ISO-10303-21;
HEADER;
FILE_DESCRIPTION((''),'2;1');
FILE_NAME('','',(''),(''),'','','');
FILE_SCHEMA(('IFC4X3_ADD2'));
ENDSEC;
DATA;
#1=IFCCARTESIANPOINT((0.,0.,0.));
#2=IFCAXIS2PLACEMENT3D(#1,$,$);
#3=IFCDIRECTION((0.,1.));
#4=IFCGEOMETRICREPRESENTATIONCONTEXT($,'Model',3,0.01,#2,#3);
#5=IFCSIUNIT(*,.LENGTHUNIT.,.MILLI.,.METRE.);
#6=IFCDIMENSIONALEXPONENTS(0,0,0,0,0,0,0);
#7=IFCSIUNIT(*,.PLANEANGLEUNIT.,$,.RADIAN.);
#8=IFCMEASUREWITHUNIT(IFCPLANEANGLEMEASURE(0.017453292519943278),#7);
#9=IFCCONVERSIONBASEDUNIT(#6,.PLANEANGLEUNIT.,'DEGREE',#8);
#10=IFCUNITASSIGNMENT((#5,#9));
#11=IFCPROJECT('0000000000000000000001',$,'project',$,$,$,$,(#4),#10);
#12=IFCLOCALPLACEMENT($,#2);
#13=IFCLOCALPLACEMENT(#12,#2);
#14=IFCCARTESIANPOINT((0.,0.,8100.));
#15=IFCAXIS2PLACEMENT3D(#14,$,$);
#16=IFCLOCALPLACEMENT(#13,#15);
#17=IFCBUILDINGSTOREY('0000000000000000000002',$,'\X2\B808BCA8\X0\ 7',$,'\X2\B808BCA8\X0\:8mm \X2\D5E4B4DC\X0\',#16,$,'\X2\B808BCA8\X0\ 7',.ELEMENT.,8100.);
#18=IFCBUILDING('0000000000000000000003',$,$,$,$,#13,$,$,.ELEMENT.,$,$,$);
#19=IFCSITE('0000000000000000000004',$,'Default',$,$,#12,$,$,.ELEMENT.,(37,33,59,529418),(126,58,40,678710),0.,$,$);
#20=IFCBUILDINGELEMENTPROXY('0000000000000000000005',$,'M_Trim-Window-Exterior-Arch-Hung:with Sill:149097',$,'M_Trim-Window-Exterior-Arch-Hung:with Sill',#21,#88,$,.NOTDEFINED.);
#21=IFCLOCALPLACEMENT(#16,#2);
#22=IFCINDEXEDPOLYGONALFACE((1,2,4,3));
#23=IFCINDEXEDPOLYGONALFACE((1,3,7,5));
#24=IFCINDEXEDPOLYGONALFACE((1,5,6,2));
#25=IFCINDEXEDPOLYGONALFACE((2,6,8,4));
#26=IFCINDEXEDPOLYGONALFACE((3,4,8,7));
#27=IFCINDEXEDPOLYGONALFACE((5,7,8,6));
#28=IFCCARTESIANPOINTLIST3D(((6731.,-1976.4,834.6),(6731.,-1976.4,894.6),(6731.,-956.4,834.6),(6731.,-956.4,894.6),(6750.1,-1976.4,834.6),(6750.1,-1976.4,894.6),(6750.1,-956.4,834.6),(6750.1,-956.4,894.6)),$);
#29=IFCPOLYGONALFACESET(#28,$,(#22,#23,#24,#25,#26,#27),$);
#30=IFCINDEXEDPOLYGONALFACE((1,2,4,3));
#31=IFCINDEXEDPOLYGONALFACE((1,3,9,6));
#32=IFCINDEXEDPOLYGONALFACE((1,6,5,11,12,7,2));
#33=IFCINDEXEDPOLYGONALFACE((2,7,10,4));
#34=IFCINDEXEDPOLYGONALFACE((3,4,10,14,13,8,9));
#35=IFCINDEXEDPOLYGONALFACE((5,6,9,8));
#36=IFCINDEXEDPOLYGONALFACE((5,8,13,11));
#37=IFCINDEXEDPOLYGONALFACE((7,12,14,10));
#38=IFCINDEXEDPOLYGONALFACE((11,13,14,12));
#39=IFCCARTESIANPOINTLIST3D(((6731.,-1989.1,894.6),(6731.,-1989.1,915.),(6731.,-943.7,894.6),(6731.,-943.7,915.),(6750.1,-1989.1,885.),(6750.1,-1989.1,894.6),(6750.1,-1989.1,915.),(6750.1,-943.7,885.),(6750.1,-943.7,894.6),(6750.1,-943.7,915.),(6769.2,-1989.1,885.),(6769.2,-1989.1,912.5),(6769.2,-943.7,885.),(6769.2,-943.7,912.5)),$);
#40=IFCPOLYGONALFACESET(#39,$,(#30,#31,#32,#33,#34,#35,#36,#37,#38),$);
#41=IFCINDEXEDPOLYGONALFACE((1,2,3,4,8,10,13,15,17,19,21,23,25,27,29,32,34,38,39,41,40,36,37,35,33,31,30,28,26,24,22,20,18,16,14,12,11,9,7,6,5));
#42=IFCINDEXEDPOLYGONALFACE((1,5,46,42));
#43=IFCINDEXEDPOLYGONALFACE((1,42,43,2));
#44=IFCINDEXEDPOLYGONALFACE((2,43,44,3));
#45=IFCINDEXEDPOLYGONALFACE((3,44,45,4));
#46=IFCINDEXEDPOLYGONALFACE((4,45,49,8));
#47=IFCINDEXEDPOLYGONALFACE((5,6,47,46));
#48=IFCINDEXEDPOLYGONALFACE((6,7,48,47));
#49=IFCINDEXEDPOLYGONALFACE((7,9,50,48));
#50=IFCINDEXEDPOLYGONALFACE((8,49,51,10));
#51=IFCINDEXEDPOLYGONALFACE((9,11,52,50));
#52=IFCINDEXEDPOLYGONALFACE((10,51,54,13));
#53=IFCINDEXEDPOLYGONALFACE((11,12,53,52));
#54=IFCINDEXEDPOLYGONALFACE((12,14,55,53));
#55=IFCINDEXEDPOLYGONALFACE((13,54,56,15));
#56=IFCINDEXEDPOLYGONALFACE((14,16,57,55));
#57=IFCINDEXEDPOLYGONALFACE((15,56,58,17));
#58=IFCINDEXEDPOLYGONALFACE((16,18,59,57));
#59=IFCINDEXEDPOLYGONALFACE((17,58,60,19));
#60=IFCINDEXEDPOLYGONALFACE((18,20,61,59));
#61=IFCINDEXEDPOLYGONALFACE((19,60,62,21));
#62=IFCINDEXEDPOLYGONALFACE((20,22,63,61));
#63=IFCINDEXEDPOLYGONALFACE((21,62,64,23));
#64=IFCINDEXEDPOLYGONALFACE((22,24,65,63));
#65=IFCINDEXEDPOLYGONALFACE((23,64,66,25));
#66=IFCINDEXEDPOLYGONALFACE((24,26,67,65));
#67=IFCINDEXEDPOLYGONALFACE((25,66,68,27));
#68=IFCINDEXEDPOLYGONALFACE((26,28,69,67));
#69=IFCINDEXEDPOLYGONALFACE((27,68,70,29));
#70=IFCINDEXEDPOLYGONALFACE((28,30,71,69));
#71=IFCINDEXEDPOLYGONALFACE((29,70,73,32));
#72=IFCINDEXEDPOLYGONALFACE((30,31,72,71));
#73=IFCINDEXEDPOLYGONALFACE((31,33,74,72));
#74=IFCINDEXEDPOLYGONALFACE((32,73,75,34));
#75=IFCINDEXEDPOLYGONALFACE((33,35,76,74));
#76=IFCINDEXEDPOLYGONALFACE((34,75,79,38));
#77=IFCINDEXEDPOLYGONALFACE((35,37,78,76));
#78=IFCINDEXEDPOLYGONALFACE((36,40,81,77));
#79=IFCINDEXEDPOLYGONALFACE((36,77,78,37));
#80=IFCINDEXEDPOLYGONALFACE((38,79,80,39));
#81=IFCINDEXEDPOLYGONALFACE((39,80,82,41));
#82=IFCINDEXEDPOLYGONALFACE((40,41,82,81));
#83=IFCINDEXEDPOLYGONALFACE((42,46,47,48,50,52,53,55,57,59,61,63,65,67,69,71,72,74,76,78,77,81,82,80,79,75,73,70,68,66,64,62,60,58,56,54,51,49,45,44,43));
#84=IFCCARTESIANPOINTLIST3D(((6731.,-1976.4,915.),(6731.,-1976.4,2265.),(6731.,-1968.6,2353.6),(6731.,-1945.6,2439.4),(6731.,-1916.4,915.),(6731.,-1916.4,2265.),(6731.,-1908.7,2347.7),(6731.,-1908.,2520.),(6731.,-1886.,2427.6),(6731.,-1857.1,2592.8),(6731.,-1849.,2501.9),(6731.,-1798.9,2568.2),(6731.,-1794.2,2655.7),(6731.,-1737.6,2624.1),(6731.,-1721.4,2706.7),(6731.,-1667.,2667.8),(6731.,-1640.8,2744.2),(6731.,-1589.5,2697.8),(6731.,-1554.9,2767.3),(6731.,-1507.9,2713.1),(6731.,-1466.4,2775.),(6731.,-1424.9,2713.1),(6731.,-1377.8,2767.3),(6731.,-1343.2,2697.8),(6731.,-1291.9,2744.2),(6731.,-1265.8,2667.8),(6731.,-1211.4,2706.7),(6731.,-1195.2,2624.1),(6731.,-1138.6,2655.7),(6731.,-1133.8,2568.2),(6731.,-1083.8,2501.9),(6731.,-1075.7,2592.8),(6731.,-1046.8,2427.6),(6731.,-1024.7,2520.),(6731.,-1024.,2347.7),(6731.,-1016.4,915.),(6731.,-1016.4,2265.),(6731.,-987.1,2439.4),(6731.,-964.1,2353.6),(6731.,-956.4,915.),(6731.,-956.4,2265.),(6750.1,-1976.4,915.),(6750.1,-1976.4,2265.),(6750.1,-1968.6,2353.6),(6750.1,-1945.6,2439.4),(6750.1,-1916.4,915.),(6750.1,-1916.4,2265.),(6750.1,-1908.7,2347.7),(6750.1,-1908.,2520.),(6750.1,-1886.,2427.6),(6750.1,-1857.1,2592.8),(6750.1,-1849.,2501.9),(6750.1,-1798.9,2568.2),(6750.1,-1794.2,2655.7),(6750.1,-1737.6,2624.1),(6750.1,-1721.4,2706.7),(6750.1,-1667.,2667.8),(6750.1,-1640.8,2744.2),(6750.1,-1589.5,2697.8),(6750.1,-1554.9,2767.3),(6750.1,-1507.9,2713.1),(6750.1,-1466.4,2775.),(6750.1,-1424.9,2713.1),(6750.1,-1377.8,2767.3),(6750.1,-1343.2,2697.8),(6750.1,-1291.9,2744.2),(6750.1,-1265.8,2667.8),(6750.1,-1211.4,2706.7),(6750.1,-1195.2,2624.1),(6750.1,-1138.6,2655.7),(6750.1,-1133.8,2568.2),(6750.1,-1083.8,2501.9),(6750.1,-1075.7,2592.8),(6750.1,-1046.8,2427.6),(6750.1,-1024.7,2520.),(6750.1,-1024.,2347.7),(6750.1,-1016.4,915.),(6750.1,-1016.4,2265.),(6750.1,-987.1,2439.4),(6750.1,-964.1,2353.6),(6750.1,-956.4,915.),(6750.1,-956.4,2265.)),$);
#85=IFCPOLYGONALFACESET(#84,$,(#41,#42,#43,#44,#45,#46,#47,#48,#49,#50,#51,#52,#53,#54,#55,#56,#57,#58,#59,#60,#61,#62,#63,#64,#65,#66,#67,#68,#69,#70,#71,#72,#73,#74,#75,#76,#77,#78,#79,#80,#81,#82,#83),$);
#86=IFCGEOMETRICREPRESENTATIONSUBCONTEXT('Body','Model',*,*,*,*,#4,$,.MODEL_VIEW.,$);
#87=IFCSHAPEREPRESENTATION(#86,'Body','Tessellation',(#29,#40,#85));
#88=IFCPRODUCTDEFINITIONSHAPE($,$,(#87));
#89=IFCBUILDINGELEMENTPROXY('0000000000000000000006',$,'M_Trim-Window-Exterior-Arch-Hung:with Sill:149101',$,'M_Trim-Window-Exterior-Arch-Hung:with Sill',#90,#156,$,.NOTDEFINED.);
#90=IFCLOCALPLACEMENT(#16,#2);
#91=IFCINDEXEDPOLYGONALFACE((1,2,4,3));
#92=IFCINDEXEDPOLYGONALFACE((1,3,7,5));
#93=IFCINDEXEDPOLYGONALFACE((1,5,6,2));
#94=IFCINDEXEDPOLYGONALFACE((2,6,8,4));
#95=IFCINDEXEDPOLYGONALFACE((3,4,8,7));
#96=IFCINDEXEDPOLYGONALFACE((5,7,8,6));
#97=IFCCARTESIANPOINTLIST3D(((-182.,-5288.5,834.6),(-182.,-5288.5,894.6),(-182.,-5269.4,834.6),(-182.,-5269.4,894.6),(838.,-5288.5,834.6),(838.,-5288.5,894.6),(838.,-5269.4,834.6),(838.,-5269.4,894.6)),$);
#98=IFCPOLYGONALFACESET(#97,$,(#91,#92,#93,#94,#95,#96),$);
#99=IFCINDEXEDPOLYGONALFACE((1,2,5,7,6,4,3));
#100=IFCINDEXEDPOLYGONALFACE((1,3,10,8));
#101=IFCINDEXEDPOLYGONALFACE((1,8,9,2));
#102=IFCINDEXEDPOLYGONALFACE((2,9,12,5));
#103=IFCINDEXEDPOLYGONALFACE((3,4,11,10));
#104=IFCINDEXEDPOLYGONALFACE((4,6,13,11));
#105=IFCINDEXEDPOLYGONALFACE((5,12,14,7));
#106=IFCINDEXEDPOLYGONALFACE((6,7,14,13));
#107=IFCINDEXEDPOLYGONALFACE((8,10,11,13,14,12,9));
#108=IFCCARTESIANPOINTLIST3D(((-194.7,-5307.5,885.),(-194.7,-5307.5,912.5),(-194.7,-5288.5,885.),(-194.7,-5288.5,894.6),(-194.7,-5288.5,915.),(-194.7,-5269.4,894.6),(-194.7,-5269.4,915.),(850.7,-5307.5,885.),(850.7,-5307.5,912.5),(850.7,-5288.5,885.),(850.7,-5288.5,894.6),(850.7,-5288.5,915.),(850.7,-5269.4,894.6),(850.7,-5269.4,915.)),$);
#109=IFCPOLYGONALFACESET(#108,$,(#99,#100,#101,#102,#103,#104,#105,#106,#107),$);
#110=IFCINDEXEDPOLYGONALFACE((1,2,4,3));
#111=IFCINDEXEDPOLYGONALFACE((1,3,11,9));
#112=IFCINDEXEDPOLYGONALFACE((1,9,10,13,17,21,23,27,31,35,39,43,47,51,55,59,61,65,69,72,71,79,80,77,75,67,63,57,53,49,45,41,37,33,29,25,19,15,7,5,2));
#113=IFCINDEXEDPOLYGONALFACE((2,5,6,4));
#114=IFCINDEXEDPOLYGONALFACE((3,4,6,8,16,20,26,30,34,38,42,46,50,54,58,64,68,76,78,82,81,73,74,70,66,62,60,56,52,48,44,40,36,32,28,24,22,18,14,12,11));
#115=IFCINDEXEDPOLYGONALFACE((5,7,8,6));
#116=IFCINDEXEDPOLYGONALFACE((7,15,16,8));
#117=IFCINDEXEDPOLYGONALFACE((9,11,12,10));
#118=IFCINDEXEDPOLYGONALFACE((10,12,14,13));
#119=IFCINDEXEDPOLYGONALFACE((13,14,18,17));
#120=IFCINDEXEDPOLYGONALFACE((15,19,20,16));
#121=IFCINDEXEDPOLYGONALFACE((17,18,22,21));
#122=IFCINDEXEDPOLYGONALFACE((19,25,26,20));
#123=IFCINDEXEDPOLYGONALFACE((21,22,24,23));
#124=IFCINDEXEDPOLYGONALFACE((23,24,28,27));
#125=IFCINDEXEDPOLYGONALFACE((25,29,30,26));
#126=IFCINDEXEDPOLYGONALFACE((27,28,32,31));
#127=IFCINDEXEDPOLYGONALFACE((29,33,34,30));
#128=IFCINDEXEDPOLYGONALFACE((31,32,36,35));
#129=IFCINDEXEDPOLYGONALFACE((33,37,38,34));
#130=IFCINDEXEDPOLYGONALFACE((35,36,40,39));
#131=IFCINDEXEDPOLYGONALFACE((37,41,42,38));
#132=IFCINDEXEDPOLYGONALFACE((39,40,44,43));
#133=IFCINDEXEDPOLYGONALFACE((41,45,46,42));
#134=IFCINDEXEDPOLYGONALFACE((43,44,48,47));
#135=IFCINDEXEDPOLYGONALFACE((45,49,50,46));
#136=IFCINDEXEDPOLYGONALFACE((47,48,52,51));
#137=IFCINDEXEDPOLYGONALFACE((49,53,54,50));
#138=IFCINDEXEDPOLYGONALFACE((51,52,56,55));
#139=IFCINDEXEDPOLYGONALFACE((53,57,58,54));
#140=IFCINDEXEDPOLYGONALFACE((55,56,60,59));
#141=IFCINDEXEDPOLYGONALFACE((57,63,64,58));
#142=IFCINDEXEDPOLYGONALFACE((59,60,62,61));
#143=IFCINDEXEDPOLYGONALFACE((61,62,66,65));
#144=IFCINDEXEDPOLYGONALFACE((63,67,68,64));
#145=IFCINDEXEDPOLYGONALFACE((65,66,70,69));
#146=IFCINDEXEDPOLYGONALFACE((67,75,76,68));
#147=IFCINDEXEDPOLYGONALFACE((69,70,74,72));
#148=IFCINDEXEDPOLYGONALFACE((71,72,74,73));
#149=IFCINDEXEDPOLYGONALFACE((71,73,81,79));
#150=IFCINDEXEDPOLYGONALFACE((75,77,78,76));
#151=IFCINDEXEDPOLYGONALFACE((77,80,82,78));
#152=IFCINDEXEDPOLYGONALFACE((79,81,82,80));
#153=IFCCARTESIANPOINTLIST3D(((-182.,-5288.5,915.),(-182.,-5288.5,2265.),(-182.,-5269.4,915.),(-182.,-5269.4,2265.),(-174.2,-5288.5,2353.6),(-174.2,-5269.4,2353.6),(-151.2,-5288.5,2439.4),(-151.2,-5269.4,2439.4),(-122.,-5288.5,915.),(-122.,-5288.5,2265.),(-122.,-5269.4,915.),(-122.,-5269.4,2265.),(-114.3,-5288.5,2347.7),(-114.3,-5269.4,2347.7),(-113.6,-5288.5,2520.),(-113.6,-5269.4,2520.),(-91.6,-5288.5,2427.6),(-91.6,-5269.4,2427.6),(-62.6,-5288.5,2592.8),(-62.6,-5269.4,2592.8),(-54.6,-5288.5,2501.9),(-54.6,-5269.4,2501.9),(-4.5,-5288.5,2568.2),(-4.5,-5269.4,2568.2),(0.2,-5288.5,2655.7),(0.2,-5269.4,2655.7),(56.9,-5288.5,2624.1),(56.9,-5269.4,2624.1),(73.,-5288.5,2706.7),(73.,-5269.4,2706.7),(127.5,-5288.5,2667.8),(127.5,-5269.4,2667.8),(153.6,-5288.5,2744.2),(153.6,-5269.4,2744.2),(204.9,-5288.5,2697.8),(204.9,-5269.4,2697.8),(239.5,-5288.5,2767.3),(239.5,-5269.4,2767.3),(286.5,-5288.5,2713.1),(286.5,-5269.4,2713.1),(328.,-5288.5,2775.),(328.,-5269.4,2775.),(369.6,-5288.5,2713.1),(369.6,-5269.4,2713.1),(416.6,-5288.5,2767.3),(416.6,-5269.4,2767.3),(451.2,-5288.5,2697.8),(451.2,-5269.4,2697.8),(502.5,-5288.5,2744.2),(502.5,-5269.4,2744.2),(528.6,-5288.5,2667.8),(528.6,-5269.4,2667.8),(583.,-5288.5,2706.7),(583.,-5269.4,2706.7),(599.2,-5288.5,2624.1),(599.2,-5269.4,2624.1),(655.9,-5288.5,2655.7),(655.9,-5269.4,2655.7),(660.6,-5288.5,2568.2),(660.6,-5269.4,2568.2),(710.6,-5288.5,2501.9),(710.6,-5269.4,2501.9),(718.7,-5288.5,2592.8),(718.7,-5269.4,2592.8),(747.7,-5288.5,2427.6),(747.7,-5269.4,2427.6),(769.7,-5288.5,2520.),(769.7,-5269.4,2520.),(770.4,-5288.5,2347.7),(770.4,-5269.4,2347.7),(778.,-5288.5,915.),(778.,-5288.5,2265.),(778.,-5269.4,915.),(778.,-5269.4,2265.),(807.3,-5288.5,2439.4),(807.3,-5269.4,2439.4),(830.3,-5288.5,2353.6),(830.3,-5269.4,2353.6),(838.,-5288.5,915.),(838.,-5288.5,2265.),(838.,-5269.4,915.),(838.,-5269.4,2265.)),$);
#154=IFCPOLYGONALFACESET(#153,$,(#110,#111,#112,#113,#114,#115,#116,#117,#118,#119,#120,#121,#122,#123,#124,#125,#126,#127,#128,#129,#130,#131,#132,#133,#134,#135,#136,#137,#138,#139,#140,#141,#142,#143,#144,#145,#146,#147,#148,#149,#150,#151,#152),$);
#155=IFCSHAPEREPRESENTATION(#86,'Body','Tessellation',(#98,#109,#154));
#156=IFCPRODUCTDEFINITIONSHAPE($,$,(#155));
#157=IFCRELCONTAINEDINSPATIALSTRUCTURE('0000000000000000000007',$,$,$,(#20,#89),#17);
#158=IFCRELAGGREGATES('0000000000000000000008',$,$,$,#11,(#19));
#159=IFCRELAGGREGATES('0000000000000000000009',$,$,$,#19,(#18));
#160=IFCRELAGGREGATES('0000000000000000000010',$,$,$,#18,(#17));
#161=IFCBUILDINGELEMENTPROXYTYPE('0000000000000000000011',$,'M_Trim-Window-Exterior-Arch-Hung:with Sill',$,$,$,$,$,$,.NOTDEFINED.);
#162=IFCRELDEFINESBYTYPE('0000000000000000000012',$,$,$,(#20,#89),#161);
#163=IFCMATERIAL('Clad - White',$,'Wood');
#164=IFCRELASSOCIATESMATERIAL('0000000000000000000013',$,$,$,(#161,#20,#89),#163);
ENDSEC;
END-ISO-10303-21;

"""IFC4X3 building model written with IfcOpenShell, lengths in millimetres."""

from ifc_helpers import new_model, entity, si_unit, converted_unit, direction, frame, frame_2d, origin, place, context, subcontext, project, spatial, polyline, circle_curve, parameter, trimmed, segment, composite_curve, rectangle, outline, extrude, source, transform, mapped, material, type_object, type_shapes, element, save


model = new_model("IFC4X3")

# Units and contexts
model_context = context("Model", 3, precision=0.01, world=origin(), true_north=direction((0.0, 1.0)))
body_context = subcontext(model_context, "Body", "Model", "MODEL_VIEW")
ifc_project = project(units=[si_unit("LENGTHUNIT", "METRE", prefix="MILLI"), converted_unit("PLANEANGLEUNIT", "DEGREE", entity("IfcPlaneAngleMeasure", 0.017453292519943278), si_unit("PLANEANGLEUNIT", "RADIAN"), dimensions=[0, 0, 0, 0, 0, 0, 0])], contexts=[model_context])

# Site, building, storey
site_placement = place(None, origin())
site = spatial("IfcSite", under=ifc_project, at=site_placement, Name="Default", CompositionType="ELEMENT", RefLatitude=(37, 33, 59, 529418), RefLongitude=(126, 58, 40, 678710), RefElevation=0.0)
building_placement = place(site_placement, origin())
building = spatial("IfcBuilding", under=site, at=building_placement, CompositionType="ELEMENT")
storey_placement = place(building_placement, frame((0.0, 0.0, 8100.0)))
storey = spatial("IfcBuildingStorey", under=building, at=storey_placement, Name="레벨 7", ObjectType="레벨:8mm 헤드", LongName="레벨 7", CompositionType="ELEMENT", Elevation=8100.0)

# Building element proxies
ifc_material_1 = material(Name="Clad - White", Category="Wood")
building_element_proxy_type_1 = type_object("IfcBuildingElementProxyType", Name="M_Trim-Window-Exterior-Arch-Hung:with Sill", PredefinedType="NOTDEFINED", material=ifc_material_1)
shared_shape_1 = source(origin(), body_context, "Body", "SweptSolid", [
    extrude(rectangle(XDim=1020.0, YDim=60.0, at=frame_2d((0.0, 0.0), x_axis=(1.0, 0.0))), frame((0.0, -1850.4, 0.0), z_axis=(0.0, 0.0, 1.0), x_axis=(-1.0, 0.0, 0.0)), (0.0, 0.0, 1.0), 19.1),
    extrude(outline(polyline([(-19.1, -15.2), (0.0, -15.2), (0.0, -5.7), (19.1, -5.7), (19.1, 14.8), (0.0, 14.8), (-19.1, 12.3), (-19.1, -15.2)])), frame((-522.7, -1814.8, 19.1), z_axis=(1.0, 0.0, 0.0), x_axis=(0.0, 0.0, -1.0)), (0.0, 0.0, 1.0), 1045.4),
    extrude(outline(composite_curve([segment(polyline([(-675.0, -510.0), (675.0, -510.0)]), True, "CONTINUOUS"), segment(polyline([(675.0, -510.0), (675.0, -450.0)]), True, "CONTINUOUS"), segment(polyline([(675.0, -450.0), (-675.0, -450.0)]), True, "CONTINUOUS"), segment(trimmed(circle_curve(frame_2d((-675.0, 0.0), x_axis=(0.0, 1.0)), 450.0), [parameter(0.0)], [parameter(180.0)], True, "PARAMETER"), False, "CONTINUOUS"), segment(polyline([(-675.0, 450.0), (675.0, 450.0)]), True, "CONTINUOUS"), segment(polyline([(675.0, 450.0), (675.0, 510.0)]), True, "CONTINUOUS"), segment(polyline([(675.0, 510.0), (-675.0, 510.0)]), True, "CONTINUOUS"), segment(trimmed(circle_curve(frame_2d((-675.0, 0.0), x_axis=(0.0, 1.0)), 510.0), [parameter(0.0)], [parameter(180.0)], True, "PARAMETER"), True, "CONTINUOUS")], self_intersect=False)), frame((0.0, -1125.0, 0.0), z_axis=(0.0, 0.0, 1.0), x_axis=(0.0, -1.0, 0.0)), (0.0, 0.0, 1.0), 19.1),
])
type_shapes(building_element_proxy_type_1, [shared_shape_1])
for number, where, z_axis, x_axis, name in (
    (1, (6731.0, -1466.4, 2715.0), (1.0, 0.0, 0.0), (0.0, 1.0, 0.0), "M_Trim-Window-Exterior-Arch-Hung:with Sill:149097"),
    (2, (328.0, -5269.4, 2715.0), (0.0, -1.0, 0.0), (1.0, 0.0, 0.0), "M_Trim-Window-Exterior-Arch-Hung:with Sill:149101"),
):
    element("IfcBuildingElementProxy", number, at=place(storey_placement, frame(where, z_axis=z_axis, x_axis=x_axis)), inside=storey, type_object=building_element_proxy_type_1, material=ifc_material_1, Name=name, ObjectType="M_Trim-Window-Exterior-Arch-Hung:with Sill", PredefinedType="NOTDEFINED", context=body_context, shape_type="MappedRepresentation", body=[
        mapped(shared_shape_1, transform((0.0, 0.0, 0.0), scale=1.0)),
    ])

save(model, "model.ifc")
